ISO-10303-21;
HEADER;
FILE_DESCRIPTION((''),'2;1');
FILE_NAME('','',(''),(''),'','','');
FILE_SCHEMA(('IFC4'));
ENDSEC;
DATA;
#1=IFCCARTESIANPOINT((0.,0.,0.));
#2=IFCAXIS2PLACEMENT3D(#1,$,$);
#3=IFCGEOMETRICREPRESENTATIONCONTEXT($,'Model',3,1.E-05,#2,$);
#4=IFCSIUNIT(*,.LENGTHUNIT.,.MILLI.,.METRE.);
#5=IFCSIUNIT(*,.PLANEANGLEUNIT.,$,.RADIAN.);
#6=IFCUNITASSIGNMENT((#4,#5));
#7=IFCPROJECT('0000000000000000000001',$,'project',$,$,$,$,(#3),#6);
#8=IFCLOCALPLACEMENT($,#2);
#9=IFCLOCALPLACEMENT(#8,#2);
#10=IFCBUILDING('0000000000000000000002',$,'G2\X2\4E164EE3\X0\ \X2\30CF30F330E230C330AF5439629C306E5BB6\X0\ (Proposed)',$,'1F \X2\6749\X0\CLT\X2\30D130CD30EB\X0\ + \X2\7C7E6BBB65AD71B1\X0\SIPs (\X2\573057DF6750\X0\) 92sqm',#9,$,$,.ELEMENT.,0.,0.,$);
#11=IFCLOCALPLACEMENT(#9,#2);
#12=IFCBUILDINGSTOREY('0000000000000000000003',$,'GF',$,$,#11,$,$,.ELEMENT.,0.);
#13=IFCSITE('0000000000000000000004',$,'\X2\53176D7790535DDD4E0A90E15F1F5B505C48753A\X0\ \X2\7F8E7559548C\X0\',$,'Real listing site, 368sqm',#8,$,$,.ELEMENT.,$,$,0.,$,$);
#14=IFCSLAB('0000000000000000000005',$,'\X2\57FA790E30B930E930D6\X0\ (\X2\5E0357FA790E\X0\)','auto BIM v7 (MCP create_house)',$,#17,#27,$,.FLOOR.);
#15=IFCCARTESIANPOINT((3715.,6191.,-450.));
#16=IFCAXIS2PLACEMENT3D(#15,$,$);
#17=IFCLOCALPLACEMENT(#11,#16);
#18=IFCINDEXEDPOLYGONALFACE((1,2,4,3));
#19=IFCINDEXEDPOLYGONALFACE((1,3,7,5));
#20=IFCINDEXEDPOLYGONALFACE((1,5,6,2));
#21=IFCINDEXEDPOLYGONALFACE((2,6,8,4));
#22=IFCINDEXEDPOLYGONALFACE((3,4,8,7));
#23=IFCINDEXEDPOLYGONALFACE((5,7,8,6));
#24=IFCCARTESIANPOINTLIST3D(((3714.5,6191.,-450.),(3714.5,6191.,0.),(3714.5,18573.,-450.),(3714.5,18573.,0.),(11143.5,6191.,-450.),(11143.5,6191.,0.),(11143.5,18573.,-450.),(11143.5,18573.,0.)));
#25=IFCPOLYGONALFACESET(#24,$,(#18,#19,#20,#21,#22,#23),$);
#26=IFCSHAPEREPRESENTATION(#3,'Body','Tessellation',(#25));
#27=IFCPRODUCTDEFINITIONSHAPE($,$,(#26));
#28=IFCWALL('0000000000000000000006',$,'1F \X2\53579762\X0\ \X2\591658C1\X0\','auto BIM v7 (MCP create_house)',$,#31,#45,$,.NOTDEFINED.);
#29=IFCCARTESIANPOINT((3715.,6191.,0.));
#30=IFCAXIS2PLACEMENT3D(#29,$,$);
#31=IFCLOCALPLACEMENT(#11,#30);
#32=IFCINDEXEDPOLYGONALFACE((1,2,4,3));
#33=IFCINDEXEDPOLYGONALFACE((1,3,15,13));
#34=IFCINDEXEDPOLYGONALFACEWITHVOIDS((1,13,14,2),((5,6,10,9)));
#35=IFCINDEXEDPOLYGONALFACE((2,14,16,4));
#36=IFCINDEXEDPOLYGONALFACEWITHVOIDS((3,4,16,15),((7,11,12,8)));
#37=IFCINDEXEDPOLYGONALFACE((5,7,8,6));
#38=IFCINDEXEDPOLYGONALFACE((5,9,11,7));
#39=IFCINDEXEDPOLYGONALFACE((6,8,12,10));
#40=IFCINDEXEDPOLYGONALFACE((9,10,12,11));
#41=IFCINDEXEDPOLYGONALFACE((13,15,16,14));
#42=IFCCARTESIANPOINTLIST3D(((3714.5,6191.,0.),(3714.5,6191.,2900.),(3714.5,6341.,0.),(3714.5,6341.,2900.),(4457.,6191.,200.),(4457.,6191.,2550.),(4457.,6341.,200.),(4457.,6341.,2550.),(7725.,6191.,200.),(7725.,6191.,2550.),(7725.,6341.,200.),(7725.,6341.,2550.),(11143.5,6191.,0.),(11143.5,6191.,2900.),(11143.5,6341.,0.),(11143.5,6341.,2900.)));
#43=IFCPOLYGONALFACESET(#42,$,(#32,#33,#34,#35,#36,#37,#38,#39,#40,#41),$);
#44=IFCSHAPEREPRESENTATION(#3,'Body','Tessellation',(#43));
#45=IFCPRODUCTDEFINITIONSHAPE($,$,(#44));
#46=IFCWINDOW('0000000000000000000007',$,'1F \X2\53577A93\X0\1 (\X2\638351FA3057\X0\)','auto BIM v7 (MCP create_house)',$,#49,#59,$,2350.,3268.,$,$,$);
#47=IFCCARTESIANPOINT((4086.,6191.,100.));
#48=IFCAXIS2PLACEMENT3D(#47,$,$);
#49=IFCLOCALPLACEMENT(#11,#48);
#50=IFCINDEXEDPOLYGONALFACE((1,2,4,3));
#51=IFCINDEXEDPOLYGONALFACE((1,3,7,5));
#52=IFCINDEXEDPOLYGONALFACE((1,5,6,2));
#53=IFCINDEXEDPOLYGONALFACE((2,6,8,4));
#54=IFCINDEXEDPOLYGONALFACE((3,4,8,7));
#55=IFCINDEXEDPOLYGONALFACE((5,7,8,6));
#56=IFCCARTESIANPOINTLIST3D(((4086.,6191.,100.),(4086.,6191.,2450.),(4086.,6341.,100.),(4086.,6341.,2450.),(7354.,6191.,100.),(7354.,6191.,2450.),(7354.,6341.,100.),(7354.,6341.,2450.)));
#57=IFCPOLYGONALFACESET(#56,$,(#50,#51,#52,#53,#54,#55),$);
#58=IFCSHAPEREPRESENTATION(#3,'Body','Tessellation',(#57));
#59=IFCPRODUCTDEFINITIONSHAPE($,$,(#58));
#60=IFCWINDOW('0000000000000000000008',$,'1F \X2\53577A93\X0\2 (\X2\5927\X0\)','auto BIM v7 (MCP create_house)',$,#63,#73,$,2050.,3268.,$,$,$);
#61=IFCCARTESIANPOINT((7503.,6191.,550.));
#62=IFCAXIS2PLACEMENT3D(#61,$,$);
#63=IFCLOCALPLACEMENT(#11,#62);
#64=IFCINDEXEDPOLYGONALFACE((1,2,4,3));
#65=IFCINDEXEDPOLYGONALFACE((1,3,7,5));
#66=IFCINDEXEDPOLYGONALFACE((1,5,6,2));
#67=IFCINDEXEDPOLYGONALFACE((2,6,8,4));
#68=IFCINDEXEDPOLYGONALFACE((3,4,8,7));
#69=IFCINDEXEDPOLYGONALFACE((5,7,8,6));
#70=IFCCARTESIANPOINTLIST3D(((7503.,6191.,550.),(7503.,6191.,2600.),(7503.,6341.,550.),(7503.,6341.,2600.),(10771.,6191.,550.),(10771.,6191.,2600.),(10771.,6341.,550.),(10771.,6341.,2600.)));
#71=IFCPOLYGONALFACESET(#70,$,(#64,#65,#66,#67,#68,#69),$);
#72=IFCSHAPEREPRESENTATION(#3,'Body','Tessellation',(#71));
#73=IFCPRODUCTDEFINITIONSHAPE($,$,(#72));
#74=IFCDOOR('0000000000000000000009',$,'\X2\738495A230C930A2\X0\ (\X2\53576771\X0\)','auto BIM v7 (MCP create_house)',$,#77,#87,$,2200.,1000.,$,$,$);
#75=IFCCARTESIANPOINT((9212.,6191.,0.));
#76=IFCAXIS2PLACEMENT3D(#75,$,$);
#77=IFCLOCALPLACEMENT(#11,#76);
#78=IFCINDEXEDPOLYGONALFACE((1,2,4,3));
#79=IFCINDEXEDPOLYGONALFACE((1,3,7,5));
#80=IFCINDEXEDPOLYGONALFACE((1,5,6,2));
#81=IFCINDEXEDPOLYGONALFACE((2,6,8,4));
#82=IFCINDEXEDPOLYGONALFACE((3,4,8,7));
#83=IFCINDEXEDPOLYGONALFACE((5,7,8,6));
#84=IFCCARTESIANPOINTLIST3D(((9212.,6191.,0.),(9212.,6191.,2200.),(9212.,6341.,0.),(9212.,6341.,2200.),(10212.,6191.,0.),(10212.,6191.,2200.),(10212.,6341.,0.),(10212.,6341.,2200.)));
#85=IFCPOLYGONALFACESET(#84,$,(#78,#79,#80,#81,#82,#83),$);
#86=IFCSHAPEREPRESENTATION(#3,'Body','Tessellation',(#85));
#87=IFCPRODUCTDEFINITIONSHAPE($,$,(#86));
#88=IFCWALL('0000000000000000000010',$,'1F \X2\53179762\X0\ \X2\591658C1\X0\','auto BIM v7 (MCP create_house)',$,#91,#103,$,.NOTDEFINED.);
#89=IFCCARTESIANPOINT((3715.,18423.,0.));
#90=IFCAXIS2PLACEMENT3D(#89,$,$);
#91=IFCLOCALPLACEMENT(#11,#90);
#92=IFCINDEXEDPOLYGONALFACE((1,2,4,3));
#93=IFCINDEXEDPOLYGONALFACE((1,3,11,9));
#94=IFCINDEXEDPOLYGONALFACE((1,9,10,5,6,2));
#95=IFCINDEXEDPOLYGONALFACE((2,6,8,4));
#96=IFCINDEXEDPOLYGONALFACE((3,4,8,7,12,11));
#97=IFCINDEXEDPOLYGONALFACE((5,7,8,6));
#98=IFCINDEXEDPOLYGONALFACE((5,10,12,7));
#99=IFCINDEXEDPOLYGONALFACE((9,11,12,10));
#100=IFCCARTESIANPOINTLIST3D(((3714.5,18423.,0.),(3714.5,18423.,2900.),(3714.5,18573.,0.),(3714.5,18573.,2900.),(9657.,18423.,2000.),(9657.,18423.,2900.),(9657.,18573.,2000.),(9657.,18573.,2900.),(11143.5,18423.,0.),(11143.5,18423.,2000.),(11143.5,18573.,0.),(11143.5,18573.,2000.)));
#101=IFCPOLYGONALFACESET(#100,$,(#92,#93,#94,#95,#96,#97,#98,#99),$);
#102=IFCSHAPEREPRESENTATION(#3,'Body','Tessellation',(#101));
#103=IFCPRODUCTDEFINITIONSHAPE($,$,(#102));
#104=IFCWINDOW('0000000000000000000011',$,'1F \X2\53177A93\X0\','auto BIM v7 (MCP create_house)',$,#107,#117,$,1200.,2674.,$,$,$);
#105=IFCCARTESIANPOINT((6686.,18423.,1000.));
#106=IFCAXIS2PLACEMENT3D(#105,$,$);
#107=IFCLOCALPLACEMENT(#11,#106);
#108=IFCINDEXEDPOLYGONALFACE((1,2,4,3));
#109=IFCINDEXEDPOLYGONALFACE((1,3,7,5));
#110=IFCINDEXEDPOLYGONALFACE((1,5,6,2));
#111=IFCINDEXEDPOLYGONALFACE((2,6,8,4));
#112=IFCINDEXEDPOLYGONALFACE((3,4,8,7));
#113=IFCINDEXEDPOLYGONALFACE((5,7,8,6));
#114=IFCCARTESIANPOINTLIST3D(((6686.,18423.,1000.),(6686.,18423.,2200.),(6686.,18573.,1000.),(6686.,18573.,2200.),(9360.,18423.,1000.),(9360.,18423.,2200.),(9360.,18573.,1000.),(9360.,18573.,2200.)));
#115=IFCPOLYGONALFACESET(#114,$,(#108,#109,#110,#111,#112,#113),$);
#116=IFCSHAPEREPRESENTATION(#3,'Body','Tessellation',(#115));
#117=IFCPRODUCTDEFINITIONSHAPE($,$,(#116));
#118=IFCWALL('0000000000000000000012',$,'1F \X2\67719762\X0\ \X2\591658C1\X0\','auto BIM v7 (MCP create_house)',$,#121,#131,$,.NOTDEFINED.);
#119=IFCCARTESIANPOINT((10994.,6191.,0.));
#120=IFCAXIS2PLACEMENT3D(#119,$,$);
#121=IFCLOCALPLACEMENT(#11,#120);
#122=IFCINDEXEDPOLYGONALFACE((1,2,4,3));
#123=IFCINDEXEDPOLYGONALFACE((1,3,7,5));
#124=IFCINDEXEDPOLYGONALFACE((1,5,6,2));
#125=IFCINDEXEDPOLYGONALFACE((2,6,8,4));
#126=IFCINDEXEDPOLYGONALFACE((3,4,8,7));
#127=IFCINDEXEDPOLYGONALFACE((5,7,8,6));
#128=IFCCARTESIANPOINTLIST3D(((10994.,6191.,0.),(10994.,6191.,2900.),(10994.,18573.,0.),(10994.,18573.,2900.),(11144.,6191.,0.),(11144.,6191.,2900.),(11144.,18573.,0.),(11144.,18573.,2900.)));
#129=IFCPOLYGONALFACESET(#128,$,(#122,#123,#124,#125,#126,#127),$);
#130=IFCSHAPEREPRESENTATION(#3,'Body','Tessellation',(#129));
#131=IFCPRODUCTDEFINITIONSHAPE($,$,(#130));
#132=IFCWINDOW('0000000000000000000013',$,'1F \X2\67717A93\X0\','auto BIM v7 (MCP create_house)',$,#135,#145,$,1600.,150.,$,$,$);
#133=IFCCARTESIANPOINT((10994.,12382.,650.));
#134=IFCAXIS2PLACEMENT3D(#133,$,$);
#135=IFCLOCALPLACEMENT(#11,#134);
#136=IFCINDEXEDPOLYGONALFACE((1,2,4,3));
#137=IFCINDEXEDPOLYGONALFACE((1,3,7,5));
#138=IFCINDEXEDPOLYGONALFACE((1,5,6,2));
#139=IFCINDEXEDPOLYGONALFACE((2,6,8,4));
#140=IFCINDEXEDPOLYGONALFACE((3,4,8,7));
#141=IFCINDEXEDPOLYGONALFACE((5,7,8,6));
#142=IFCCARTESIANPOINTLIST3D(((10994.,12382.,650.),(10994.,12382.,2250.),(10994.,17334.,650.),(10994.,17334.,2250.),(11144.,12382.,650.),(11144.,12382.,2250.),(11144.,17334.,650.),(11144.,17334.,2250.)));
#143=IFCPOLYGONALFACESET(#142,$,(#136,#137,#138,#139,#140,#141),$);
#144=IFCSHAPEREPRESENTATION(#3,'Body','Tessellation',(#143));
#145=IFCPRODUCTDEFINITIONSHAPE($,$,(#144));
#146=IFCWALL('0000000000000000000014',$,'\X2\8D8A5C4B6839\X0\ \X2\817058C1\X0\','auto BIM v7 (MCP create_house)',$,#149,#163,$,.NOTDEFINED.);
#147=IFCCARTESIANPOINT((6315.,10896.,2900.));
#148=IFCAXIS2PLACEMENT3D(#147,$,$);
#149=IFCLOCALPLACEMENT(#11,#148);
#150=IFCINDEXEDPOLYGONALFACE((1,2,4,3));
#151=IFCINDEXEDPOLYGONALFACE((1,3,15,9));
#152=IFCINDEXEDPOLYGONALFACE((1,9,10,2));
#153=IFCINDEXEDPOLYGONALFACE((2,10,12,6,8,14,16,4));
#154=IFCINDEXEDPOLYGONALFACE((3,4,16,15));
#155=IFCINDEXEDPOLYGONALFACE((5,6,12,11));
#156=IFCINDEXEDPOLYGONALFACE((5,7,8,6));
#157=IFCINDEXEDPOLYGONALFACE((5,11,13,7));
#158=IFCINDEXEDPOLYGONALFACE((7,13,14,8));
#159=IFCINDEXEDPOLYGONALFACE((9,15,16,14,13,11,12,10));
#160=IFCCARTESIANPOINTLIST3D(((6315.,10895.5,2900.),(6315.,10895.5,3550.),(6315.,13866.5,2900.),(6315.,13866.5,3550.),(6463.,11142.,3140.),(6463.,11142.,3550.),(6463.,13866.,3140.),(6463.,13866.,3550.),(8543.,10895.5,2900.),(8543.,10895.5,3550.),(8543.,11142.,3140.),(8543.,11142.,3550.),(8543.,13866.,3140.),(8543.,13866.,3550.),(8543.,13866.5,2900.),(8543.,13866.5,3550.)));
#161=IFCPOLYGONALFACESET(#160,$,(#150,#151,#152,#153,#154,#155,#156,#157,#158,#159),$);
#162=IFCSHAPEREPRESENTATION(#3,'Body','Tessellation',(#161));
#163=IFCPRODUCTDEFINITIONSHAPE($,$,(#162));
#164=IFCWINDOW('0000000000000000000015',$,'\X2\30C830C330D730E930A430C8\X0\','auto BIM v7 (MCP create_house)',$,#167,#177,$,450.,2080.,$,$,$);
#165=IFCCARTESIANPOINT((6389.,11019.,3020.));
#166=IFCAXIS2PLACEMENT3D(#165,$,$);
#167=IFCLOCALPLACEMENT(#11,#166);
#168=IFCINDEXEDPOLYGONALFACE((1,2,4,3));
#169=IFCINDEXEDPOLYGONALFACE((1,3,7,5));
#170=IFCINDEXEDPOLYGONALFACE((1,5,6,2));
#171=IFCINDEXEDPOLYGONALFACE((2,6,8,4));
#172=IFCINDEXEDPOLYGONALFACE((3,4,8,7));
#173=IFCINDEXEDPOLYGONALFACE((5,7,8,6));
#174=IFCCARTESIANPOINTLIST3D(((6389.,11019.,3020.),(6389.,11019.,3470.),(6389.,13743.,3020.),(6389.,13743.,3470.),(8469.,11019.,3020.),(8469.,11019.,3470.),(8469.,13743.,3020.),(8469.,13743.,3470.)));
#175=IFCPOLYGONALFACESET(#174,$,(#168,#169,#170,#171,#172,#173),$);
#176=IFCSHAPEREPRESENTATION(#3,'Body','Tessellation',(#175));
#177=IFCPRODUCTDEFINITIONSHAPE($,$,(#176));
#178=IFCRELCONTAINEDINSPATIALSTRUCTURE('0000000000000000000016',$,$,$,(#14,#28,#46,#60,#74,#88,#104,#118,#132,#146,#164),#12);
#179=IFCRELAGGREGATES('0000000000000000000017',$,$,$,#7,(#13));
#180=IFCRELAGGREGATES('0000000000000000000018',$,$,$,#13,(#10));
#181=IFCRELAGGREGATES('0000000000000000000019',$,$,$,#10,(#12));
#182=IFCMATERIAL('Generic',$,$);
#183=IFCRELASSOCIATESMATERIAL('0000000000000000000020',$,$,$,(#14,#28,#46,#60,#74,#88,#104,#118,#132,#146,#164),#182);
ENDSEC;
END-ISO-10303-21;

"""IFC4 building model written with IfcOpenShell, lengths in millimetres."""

from ifc_helpers import new_model, si_unit, frame, frame_2d, origin, place, context, project, spatial, rectangle, extrude, material, element, fill, save


model = new_model("IFC4")

# Units and contexts
model_context = context("Model", 3, precision=1e-05, world=origin())
ifc_project = project(units=[si_unit("LENGTHUNIT", "METRE", prefix="MILLI"), si_unit("PLANEANGLEUNIT", "RADIAN")], contexts=[model_context])

# Site, building, storey
site_placement = place(None, origin())
site = spatial("IfcSite", under=ifc_project, at=site_placement, Name="北海道川上郡弟子屈町 美留和", ObjectType="Real listing site, 368sqm", CompositionType="ELEMENT", RefElevation=0.0)
building_placement = place(site_placement, origin())
building = spatial("IfcBuilding", under=site, at=building_placement, Name="G2世代 ハンモック吹抜の家 (Proposed)", ObjectType="1F 杉CLTパネル + 籾殻断熱SIPs (地域材) 92sqm", CompositionType="ELEMENT", ElevationOfRefHeight=0.0, ElevationOfTerrain=0.0)
storey_placement = place(building_placement, origin())
storey = spatial("IfcBuildingStorey", under=building, at=storey_placement, Name="GF", CompositionType="ELEMENT", Elevation=0.0)

# Slab
ifc_material = material(Name="Generic")
slab_1_placement = place(storey_placement, frame((3715.0, 6191.0, -450.0)))
element("IfcSlab", 1, at=slab_1_placement, inside=storey, material=ifc_material, Name="基礎スラブ (布基礎)", Description="auto BIM v7 (MCP create_house)", PredefinedType="FLOOR", context=model_context, shape_type="SweptSolid", body=[
    extrude(rectangle(XDim=7429.0, YDim=12382.0, at=frame_2d((3714.0, 6191.0))), frame((3715.0, 6191.0, -450.0)), (0.0, 0.0, 1.0), 450.0),
])

# Wall, openings, windows, door
wall_1_placement = place(storey_placement, frame((3715.0, 6191.0, 0.0)))
wall_1 = element("IfcWall", 2, at=wall_1_placement, inside=storey, material=ifc_material, Name="1F 南面 外壁", Description="auto BIM v7 (MCP create_house)", PredefinedType="NOTDEFINED", context=model_context, shape_type="SweptSolid", body=[
    extrude(rectangle(XDim=7429.0, YDim=150.0, at=frame_2d((3714.0, 75.0))), frame((3715.0, 6191.0, 0.0)), (0.0, 0.0, 1.0), 2900.0),
])
opening_1_placement = place(storey_placement, frame((4086.0, 6191.0, 100.0)))
opening_1 = element("IfcOpeningElement", 3, at=opening_1_placement, cuts=wall_1, PredefinedType="NOTDEFINED", context=model_context, shape_type="SweptSolid", body=[
    extrude(rectangle(XDim=3268.0, YDim=150.0, at=frame_2d((1634.0, 75.0))), frame((4086.0, 6191.0, 100.0)), (0.0, 0.0, 1.0), 2350.0),
])
opening_2_placement = place(storey_placement, frame((7503.0, 6191.0, 550.0)))
opening_2 = element("IfcOpeningElement", 4, at=opening_2_placement, cuts=wall_1, PredefinedType="NOTDEFINED", context=model_context, shape_type="SweptSolid", body=[
    extrude(rectangle(XDim=3268.0, YDim=150.0, at=frame_2d((1634.0, 75.0))), frame((7503.0, 6191.0, 550.0)), (0.0, 0.0, 1.0), 2050.0),
])
opening_3_placement = place(storey_placement, frame((9212.0, 6191.0, 0.0)))
opening_3 = element("IfcOpeningElement", 5, at=opening_3_placement, cuts=wall_1, PredefinedType="NOTDEFINED", context=model_context, shape_type="SweptSolid", body=[
    extrude(rectangle(XDim=1000.0, YDim=150.0, at=frame_2d((500.0, 75.0))), frame((9212.0, 6191.0, 0.0)), (0.0, 0.0, 1.0), 2200.0),
])
window_1_placement = place(storey_placement, frame((4086.0, 6191.0, 100.0)))
window_1 = element("IfcWindow", 6, at=window_1_placement, inside=storey, material=ifc_material, Name="1F 南窓1 (掃出し)", Description="auto BIM v7 (MCP create_house)", OverallHeight=2350.0, OverallWidth=3268.0, context=model_context, shape_type="SweptSolid", body=[
    extrude(rectangle(XDim=3268.0, YDim=150.0, at=frame_2d((1634.0, 75.0))), frame((4086.0, 6191.0, 100.0)), (0.0, 0.0, 1.0), 2350.0),
])
fill(opening_1, window_1)
window_2_placement = place(storey_placement, frame((7503.0, 6191.0, 550.0)))
window_2 = element("IfcWindow", 7, at=window_2_placement, inside=storey, material=ifc_material, Name="1F 南窓2 (大)", Description="auto BIM v7 (MCP create_house)", OverallHeight=2050.0, OverallWidth=3268.0, context=model_context, shape_type="SweptSolid", body=[
    extrude(rectangle(XDim=3268.0, YDim=150.0, at=frame_2d((1634.0, 75.0))), frame((7503.0, 6191.0, 550.0)), (0.0, 0.0, 1.0), 2050.0),
])
fill(opening_2, window_2)
door_placement = place(storey_placement, frame((9212.0, 6191.0, 0.0)))
door = element("IfcDoor", 8, at=door_placement, inside=storey, material=ifc_material, Name="玄関ドア (南東)", Description="auto BIM v7 (MCP create_house)", OverallHeight=2200.0, OverallWidth=1000.0, context=model_context, shape_type="SweptSolid", body=[
    extrude(rectangle(XDim=1000.0, YDim=150.0, at=frame_2d((500.0, 75.0))), frame((9212.0, 6191.0, 0.0)), (0.0, 0.0, 1.0), 2200.0),
])
fill(opening_3, door)

# Walls, openings, windows
wall_2_placement = place(storey_placement, frame((3715.0, 18423.0, 0.0)))
wall_2 = element("IfcWall", 9, at=wall_2_placement, inside=storey, material=ifc_material, Name="1F 北面 外壁", Description="auto BIM v7 (MCP create_house)", PredefinedType="NOTDEFINED", context=model_context, shape_type="SweptSolid", body=[
    extrude(rectangle(XDim=7429.0, YDim=150.0, at=frame_2d((3714.0, 75.0))), frame((3715.0, 18423.0, 0.0)), (0.0, 0.0, 1.0), 2900.0),
])
opening_4_placement = place(storey_placement, frame((6686.0, 18423.0, 1000.0)))
opening_4 = element("IfcOpeningElement", 10, at=opening_4_placement, cuts=wall_2, PredefinedType="NOTDEFINED", context=model_context, shape_type="SweptSolid", body=[
    extrude(rectangle(XDim=2674.0, YDim=150.0, at=frame_2d((1337.0, 75.0))), frame((6686.0, 18423.0, 1000.0)), (0.0, 0.0, 1.0), 1200.0),
])
window_3_placement = place(storey_placement, frame((6686.0, 18423.0, 1000.0)))
window_3 = element("IfcWindow", 11, at=window_3_placement, inside=storey, material=ifc_material, Name="1F 北窓", Description="auto BIM v7 (MCP create_house)", OverallHeight=1200.0, OverallWidth=2674.0, context=model_context, shape_type="SweptSolid", body=[
    extrude(rectangle(XDim=2674.0, YDim=150.0, at=frame_2d((1337.0, 75.0))), frame((6686.0, 18423.0, 1000.0)), (0.0, 0.0, 1.0), 1200.0),
])
fill(opening_4, window_3)
wall_3_placement = place(storey_placement, frame((10994.0, 6191.0, 0.0)))
wall_3 = element("IfcWall", 12, at=wall_3_placement, inside=storey, material=ifc_material, Name="1F 東面 外壁", Description="auto BIM v7 (MCP create_house)", PredefinedType="NOTDEFINED", context=model_context, shape_type="SweptSolid", body=[
    extrude(rectangle(XDim=150.0, YDim=12382.0, at=frame_2d((75.0, 6191.0))), frame((10994.0, 6191.0, 0.0)), (0.0, 0.0, 1.0), 2900.0),
])
opening_5_placement = place(storey_placement, frame((10994.0, 12382.0, 650.0)))
opening_5 = element("IfcOpeningElement", 13, at=opening_5_placement, cuts=wall_3, PredefinedType="NOTDEFINED", context=model_context, shape_type="SweptSolid", body=[
    extrude(rectangle(XDim=150.0, YDim=4952.0, at=frame_2d((75.0, 2476.0))), frame((10994.0, 12382.0, 650.0)), (0.0, 0.0, 1.0), 1600.0),
])
window_4_placement = place(storey_placement, frame((10994.0, 12382.0, 650.0)))
window_4 = element("IfcWindow", 14, at=window_4_placement, inside=storey, material=ifc_material, Name="1F 東窓", Description="auto BIM v7 (MCP create_house)", OverallHeight=1600.0, OverallWidth=150.0, context=model_context, shape_type="SweptSolid", body=[
    extrude(rectangle(XDim=150.0, YDim=4952.0, at=frame_2d((75.0, 2476.0))), frame((10994.0, 12382.0, 650.0)), (0.0, 0.0, 1.0), 1600.0),
])
fill(opening_5, window_4)

# Wall, opening, window
wall_4_placement = place(storey_placement, frame((6315.0, 10896.0, 2900.0)))
wall_4 = element("IfcWall", 15, at=wall_4_placement, inside=storey, material=ifc_material, Name="越屋根 腰壁", Description="auto BIM v7 (MCP create_house)", PredefinedType="NOTDEFINED", context=model_context, shape_type="SweptSolid", body=[
    extrude(rectangle(XDim=2228.0, YDim=2971.0, at=frame_2d((1114.0, 1485.0))), frame((6315.0, 10896.0, 2900.0)), (0.0, 0.0, 1.0), 650.0),
])
opening_6_placement = place(storey_placement, frame((6389.0, 11019.0, 3020.0)))
opening_6 = element("IfcOpeningElement", 16, at=opening_6_placement, cuts=wall_4, PredefinedType="NOTDEFINED", context=model_context, shape_type="SweptSolid", body=[
    extrude(rectangle(XDim=2080.0, YDim=2724.0, at=frame_2d((1040.0, 1362.0))), frame((6389.0, 11019.0, 3020.0)), (0.0, 0.0, 1.0), 450.0),
])
window_5_placement = place(storey_placement, frame((6389.0, 11019.0, 3020.0)))
window_5 = element("IfcWindow", 17, at=window_5_placement, inside=storey, material=ifc_material, Name="トップライト", Description="auto BIM v7 (MCP create_house)", OverallHeight=450.0, OverallWidth=2080.0, context=model_context, shape_type="SweptSolid", body=[
    extrude(rectangle(XDim=2080.0, YDim=2724.0, at=frame_2d((1040.0, 1362.0))), frame((6389.0, 11019.0, 3020.0)), (0.0, 0.0, 1.0), 450.0),
])
fill(opening_6, window_5)

save(model, "model.ifc")
